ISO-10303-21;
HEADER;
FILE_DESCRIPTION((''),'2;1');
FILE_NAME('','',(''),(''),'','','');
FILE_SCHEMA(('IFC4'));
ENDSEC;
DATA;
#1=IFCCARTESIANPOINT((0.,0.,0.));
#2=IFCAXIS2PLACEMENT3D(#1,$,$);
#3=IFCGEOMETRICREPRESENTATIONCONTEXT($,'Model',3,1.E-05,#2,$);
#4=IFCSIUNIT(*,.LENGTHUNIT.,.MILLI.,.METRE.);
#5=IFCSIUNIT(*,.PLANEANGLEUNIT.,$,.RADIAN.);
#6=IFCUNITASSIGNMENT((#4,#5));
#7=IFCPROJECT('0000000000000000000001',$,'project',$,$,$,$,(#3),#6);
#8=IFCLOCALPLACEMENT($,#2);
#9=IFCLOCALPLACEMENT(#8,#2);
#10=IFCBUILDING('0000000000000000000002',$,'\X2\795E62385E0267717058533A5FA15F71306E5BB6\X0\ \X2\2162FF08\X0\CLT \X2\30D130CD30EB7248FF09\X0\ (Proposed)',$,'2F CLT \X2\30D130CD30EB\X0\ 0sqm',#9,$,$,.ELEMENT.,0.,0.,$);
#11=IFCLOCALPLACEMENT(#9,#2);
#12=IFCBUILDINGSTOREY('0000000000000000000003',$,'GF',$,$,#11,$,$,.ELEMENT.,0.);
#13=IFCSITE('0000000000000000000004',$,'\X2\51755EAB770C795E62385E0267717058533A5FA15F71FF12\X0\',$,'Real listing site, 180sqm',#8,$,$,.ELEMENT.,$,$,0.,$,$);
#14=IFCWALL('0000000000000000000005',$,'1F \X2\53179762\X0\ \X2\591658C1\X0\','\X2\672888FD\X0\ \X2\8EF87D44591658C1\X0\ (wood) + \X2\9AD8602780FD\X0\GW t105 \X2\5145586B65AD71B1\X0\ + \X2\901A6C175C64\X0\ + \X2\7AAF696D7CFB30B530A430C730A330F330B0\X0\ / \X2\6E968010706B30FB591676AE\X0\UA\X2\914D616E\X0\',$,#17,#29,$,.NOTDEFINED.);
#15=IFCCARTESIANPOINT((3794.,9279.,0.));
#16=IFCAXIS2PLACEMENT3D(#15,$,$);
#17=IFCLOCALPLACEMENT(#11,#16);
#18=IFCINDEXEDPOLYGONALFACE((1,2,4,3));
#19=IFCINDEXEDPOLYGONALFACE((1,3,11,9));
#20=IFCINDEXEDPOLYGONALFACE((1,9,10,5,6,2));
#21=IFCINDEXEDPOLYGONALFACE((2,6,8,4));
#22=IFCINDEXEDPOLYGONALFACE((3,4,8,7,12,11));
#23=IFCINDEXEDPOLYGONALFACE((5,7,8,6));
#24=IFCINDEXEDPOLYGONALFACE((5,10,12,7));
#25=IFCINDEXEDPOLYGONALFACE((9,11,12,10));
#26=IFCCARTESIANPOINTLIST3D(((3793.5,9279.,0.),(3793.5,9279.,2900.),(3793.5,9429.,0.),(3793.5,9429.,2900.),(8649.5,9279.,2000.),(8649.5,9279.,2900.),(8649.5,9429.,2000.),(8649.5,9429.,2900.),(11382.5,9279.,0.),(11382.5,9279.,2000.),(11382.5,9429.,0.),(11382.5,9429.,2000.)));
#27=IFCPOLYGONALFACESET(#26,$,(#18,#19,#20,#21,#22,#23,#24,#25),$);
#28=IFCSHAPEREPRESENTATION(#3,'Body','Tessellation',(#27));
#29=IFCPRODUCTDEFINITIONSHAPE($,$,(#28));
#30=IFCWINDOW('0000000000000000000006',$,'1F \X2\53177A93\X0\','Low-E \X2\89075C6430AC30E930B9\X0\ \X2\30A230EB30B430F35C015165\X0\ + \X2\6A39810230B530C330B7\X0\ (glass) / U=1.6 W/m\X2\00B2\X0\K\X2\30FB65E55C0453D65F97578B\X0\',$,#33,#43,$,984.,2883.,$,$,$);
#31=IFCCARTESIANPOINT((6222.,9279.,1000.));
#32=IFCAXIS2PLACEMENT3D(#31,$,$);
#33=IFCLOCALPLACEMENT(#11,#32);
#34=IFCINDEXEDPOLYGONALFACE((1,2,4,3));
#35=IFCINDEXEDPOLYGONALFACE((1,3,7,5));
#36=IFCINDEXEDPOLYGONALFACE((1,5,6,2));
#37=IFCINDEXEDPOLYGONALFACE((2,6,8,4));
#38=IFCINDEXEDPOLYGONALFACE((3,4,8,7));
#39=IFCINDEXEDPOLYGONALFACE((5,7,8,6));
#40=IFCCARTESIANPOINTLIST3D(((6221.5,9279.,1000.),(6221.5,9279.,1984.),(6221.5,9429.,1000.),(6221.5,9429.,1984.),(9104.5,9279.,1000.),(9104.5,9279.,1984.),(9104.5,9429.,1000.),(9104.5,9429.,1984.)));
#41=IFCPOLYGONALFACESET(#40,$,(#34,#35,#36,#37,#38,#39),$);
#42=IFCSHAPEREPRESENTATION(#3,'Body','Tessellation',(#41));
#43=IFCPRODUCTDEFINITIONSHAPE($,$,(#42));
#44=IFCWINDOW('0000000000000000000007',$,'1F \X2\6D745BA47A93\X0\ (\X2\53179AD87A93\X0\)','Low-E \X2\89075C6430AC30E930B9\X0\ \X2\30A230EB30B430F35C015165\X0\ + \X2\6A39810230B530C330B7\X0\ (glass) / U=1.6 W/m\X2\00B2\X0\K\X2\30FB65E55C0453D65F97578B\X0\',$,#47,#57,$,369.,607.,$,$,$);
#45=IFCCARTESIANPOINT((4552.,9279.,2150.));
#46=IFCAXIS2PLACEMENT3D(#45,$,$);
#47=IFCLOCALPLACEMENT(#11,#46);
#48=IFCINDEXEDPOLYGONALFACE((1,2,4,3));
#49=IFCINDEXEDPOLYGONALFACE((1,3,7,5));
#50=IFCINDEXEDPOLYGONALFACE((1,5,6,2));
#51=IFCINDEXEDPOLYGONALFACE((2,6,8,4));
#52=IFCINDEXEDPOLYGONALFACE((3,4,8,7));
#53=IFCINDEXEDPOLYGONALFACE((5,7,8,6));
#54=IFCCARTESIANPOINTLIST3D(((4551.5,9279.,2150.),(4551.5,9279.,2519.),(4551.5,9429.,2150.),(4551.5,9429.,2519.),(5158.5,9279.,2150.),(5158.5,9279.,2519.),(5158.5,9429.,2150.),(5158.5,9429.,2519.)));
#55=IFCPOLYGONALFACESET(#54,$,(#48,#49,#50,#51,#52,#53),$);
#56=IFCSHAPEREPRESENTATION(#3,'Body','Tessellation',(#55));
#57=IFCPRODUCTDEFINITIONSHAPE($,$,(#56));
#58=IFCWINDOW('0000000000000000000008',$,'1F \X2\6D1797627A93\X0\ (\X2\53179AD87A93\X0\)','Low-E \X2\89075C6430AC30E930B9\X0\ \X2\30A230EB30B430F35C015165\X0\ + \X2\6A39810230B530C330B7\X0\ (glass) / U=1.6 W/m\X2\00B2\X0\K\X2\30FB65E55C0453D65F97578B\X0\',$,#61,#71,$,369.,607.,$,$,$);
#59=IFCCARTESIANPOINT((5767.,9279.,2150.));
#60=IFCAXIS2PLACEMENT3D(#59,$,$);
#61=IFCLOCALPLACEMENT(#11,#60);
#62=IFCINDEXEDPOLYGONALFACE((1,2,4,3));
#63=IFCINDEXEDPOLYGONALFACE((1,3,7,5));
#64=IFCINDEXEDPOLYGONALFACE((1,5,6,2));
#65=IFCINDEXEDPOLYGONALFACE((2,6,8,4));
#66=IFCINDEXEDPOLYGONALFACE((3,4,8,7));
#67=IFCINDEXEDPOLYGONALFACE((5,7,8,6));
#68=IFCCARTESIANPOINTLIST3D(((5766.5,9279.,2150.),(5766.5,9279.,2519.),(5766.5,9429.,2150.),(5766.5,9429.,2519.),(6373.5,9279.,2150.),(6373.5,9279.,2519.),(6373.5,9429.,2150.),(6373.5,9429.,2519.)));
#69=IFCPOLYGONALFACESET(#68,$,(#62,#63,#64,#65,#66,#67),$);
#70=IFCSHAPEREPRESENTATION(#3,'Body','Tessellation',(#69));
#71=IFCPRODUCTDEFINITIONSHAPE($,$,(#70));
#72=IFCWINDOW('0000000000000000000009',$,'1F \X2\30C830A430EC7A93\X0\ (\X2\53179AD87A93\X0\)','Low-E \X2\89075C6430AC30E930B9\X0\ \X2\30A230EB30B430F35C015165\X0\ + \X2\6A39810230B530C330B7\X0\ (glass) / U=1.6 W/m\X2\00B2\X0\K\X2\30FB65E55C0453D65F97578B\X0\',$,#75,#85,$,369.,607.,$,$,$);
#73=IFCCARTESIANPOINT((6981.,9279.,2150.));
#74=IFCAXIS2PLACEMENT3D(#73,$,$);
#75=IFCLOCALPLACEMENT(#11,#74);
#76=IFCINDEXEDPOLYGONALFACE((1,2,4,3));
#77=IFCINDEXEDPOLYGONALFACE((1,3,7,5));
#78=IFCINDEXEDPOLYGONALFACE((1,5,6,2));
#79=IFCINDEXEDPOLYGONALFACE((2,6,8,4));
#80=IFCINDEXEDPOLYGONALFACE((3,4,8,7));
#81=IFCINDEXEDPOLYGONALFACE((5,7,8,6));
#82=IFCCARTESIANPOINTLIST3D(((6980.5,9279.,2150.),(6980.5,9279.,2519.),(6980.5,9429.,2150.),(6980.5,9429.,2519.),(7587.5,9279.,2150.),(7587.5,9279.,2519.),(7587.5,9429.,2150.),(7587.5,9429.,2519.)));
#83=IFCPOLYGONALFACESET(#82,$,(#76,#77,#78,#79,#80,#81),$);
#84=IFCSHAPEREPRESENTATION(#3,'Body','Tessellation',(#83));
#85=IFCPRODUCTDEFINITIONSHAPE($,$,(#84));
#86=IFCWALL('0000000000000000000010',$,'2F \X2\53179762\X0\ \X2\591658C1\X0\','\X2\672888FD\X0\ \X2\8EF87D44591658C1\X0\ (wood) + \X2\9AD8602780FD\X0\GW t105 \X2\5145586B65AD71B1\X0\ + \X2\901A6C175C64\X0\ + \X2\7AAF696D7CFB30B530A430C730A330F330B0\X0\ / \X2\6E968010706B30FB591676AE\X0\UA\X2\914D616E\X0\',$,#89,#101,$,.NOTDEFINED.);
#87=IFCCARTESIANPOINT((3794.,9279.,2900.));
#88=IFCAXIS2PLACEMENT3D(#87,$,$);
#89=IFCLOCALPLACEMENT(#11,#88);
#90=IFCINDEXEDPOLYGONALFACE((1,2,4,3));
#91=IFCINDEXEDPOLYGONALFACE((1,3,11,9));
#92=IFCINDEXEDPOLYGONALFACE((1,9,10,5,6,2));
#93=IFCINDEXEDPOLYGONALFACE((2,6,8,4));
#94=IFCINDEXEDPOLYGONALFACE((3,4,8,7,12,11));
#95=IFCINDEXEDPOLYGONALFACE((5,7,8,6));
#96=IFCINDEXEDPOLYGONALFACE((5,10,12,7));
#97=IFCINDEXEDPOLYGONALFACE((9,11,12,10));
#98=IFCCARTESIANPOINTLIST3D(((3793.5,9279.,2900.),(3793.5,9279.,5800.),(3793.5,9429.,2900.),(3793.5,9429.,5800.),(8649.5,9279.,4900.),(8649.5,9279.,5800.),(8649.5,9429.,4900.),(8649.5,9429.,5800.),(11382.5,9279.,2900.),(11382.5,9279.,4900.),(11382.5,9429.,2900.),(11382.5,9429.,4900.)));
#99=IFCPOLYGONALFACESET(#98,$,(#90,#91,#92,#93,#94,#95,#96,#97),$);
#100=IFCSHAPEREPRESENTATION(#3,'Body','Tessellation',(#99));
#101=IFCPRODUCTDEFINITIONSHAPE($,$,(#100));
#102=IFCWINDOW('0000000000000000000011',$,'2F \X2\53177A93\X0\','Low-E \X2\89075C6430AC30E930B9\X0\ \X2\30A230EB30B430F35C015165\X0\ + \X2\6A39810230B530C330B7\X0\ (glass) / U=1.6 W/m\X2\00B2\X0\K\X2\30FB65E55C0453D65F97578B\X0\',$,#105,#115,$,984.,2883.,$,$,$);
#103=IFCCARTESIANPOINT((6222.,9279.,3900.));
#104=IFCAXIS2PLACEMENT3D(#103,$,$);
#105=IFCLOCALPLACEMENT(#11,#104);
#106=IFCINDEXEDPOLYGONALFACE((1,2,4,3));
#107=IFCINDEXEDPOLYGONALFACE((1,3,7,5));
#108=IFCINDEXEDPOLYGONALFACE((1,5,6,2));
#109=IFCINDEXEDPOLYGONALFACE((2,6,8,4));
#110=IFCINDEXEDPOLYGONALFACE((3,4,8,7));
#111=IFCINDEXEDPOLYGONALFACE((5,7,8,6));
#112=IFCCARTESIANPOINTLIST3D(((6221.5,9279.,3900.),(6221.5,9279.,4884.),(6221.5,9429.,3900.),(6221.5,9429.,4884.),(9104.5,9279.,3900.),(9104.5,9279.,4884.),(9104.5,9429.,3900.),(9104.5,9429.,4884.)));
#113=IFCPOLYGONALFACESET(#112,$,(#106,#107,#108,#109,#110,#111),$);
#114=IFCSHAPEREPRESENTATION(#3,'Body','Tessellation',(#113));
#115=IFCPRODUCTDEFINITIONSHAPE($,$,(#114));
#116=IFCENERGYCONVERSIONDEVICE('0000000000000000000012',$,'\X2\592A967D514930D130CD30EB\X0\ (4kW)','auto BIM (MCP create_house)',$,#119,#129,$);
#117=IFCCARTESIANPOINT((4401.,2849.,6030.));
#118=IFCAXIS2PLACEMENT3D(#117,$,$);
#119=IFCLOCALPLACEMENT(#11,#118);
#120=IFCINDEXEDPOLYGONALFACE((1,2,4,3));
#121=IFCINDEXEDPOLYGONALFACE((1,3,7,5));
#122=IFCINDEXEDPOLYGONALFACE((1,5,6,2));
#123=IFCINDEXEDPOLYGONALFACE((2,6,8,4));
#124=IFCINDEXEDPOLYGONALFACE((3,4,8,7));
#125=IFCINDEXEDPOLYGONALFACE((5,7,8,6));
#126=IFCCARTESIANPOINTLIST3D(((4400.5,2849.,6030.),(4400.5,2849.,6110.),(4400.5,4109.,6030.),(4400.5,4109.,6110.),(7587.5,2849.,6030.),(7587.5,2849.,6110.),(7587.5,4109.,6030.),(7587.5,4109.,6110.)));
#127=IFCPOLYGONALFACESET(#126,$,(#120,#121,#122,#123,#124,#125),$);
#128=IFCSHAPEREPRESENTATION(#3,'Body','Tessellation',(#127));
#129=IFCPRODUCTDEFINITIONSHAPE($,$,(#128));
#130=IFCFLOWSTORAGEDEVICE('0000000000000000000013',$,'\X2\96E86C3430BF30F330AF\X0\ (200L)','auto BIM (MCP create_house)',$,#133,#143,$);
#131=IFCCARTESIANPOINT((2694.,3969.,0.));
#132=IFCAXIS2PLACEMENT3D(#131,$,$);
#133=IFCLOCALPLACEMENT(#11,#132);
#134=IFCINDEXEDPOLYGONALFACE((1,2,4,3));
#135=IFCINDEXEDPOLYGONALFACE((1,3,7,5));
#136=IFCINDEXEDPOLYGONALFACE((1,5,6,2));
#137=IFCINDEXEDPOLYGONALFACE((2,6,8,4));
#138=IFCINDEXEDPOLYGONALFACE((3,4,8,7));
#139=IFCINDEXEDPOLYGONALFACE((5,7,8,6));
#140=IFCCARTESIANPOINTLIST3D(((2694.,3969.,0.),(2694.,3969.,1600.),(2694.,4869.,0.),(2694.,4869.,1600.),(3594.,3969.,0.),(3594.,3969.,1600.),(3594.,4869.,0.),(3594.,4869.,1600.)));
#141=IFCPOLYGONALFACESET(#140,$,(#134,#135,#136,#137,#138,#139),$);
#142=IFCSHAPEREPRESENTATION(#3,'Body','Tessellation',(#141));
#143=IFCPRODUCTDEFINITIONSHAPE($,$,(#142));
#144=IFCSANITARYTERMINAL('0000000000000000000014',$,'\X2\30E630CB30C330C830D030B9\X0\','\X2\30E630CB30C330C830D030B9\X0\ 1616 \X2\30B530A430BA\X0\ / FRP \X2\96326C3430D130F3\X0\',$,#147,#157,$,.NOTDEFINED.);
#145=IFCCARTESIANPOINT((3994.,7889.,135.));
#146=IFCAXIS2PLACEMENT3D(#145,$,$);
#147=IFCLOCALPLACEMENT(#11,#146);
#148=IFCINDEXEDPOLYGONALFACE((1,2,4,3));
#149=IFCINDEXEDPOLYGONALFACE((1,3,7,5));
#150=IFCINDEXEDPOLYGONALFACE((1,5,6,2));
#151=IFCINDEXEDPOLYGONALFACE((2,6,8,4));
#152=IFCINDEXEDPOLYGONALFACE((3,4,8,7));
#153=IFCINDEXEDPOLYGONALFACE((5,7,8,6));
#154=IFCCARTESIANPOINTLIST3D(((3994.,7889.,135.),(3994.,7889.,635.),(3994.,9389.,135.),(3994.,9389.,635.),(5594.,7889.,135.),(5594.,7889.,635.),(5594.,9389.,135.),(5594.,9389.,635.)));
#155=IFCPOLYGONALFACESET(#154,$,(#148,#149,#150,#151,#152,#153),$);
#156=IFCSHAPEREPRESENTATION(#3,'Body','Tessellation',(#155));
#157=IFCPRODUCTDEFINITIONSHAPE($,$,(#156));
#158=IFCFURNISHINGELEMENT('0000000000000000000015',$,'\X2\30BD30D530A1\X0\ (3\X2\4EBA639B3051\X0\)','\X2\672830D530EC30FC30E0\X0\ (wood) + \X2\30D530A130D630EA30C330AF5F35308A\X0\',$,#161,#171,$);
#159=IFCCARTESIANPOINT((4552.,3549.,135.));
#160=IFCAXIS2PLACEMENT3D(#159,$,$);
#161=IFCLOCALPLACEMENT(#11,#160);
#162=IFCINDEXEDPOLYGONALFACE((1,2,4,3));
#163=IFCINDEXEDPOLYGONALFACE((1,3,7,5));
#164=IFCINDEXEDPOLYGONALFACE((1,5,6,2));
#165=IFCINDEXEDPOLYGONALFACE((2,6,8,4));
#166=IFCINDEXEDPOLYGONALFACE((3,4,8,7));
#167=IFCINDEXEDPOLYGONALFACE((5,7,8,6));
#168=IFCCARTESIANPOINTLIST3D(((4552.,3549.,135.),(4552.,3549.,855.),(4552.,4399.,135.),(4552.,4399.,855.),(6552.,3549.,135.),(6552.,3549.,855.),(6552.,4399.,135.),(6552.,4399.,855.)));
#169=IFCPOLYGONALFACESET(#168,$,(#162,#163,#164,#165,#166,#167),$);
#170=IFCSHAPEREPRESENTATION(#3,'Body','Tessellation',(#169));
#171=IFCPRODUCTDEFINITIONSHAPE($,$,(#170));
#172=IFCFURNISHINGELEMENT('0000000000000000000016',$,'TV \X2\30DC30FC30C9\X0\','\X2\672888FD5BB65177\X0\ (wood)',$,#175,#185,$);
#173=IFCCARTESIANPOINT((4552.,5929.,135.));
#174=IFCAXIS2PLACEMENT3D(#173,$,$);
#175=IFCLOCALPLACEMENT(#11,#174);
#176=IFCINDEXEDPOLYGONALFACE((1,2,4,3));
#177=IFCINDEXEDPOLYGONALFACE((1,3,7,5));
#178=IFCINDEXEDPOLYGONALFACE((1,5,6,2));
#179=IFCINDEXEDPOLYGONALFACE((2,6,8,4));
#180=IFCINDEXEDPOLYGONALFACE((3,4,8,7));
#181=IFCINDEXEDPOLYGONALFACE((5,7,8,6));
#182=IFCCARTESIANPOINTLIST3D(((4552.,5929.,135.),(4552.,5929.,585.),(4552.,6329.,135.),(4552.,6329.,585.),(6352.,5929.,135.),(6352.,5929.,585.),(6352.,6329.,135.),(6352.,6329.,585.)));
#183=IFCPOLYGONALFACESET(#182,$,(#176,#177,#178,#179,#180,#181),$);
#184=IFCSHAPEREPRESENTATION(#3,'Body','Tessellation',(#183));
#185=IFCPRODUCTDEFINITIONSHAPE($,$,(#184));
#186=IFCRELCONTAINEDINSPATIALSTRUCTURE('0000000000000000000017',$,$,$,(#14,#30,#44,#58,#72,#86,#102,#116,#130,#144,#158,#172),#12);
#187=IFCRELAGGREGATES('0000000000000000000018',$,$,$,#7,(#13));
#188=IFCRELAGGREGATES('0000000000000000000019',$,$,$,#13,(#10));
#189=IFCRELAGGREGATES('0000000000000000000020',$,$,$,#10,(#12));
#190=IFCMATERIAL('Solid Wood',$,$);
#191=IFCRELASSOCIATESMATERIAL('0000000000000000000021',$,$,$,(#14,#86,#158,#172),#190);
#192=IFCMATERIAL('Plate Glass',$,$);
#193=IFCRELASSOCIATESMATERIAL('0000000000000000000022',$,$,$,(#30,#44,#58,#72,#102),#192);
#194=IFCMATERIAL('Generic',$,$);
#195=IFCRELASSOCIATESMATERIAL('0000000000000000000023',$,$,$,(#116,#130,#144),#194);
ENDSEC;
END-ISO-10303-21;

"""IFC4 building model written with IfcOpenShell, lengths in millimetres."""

from ifc_helpers import new_model, si_unit, frame, frame_2d, origin, place, context, project, spatial, rectangle, extrude, material, element, fill, save


model = new_model("IFC4")

# Units and contexts
model_context = context("Model", 3, precision=1e-05, world=origin())
ifc_project = project(units=[si_unit("LENGTHUNIT", "METRE", prefix="MILLI"), si_unit("PLANEANGLEUNIT", "RADIAN")], contexts=[model_context])

# Site, building, storey
site_placement = place(None, origin())
site = spatial("IfcSite", under=ifc_project, at=site_placement, Name="兵庫県神戸市東灘区御影２", ObjectType="Real listing site, 180sqm", CompositionType="ELEMENT", RefElevation=0.0)
building_placement = place(site_placement, origin())
building = spatial("IfcBuilding", under=site, at=building_placement, Name="神戸市東灘区御影の家 Ⅲ（CLT パネル版） (Proposed)", ObjectType="2F CLT パネル 0sqm", CompositionType="ELEMENT", ElevationOfRefHeight=0.0, ElevationOfTerrain=0.0)
storey_placement = place(building_placement, origin())
storey = spatial("IfcBuildingStorey", under=building, at=storey_placement, Name="GF", CompositionType="ELEMENT", Elevation=0.0)

# Wall, openings, windows
ifc_material_1 = material(Name="Solid Wood")
wall_1_placement = place(storey_placement, frame((3794.0, 9279.0, 0.0)))
wall_1 = element("IfcWall", 1, at=wall_1_placement, inside=storey, material=ifc_material_1, Name="1F 北面 外壁", Description="木製 軸組外壁 (wood) + 高性能GW t105 充填断熱 + 通気層 + 窯業系サイディング / 準耐火・外皮UA配慮", PredefinedType="NOTDEFINED", context=model_context, shape_type="SweptSolid", body=[
    extrude(rectangle(XDim=7589.0, YDim=150.0, at=frame_2d((3794.0, 75.0))), frame((3794.0, 9279.0, 0.0)), (0.0, 0.0, 1.0), 2900.0),
])
opening_1_placement = place(storey_placement, frame((6222.0, 9279.0, 1000.0)))
opening_1 = element("IfcOpeningElement", 2, at=opening_1_placement, cuts=wall_1, PredefinedType="NOTDEFINED", context=model_context, shape_type="SweptSolid", body=[
    extrude(rectangle(XDim=2883.0, YDim=150.0, at=frame_2d((1441.0, 75.0))), frame((6222.0, 9279.0, 1000.0)), (0.0, 0.0, 1.0), 984.0),
])
opening_2_placement = place(storey_placement, frame((4552.0, 9279.0, 2150.0)))
opening_2 = element("IfcOpeningElement", 3, at=opening_2_placement, cuts=wall_1, PredefinedType="NOTDEFINED", context=model_context, shape_type="SweptSolid", body=[
    extrude(rectangle(XDim=607.0, YDim=150.0, at=frame_2d((303.0, 75.0))), frame((4552.0, 9279.0, 2150.0)), (0.0, 0.0, 1.0), 369.0),
])
opening_3_placement = place(storey_placement, frame((5767.0, 9279.0, 2150.0)))
opening_3 = element("IfcOpeningElement", 4, at=opening_3_placement, cuts=wall_1, PredefinedType="NOTDEFINED", context=model_context, shape_type="SweptSolid", body=[
    extrude(rectangle(XDim=607.0, YDim=150.0, at=frame_2d((303.0, 75.0))), frame((5767.0, 9279.0, 2150.0)), (0.0, 0.0, 1.0), 369.0),
])
opening_4_placement = place(storey_placement, frame((6981.0, 9279.0, 2150.0)))
opening_4 = element("IfcOpeningElement", 5, at=opening_4_placement, cuts=wall_1, PredefinedType="NOTDEFINED", context=model_context, shape_type="SweptSolid", body=[
    extrude(rectangle(XDim=607.0, YDim=150.0, at=frame_2d((303.0, 75.0))), frame((6981.0, 9279.0, 2150.0)), (0.0, 0.0, 1.0), 369.0),
])
ifc_material_2 = material(Name="Plate Glass")
window_1_placement = place(storey_placement, frame((6222.0, 9279.0, 1000.0)))
window_1 = element("IfcWindow", 6, at=window_1_placement, inside=storey, material=ifc_material_2, Name="1F 北窓", Description="Low-E 複層ガラス アルゴン封入 + 樹脂サッシ (glass) / U=1.6 W/m²K・日射取得型", OverallHeight=984.0, OverallWidth=2883.0, context=model_context, shape_type="SweptSolid", body=[
    extrude(rectangle(XDim=2883.0, YDim=150.0, at=frame_2d((1441.0, 75.0))), frame((6222.0, 9279.0, 1000.0)), (0.0, 0.0, 1.0), 984.0),
])
fill(opening_1, window_1)
window_2_placement = place(storey_placement, frame((4552.0, 9279.0, 2150.0)))
window_2 = element("IfcWindow", 7, at=window_2_placement, inside=storey, material=ifc_material_2, Name="1F 浴室窓 (北高窓)", Description="Low-E 複層ガラス アルゴン封入 + 樹脂サッシ (glass) / U=1.6 W/m²K・日射取得型", OverallHeight=369.0, OverallWidth=607.0, context=model_context, shape_type="SweptSolid", body=[
    extrude(rectangle(XDim=607.0, YDim=150.0, at=frame_2d((303.0, 75.0))), frame((4552.0, 9279.0, 2150.0)), (0.0, 0.0, 1.0), 369.0),
])
fill(opening_2, window_2)
window_3_placement = place(storey_placement, frame((5767.0, 9279.0, 2150.0)))
window_3 = element("IfcWindow", 8, at=window_3_placement, inside=storey, material=ifc_material_2, Name="1F 洗面窓 (北高窓)", Description="Low-E 複層ガラス アルゴン封入 + 樹脂サッシ (glass) / U=1.6 W/m²K・日射取得型", OverallHeight=369.0, OverallWidth=607.0, context=model_context, shape_type="SweptSolid", body=[
    extrude(rectangle(XDim=607.0, YDim=150.0, at=frame_2d((303.0, 75.0))), frame((5767.0, 9279.0, 2150.0)), (0.0, 0.0, 1.0), 369.0),
])
fill(opening_3, window_3)
window_4_placement = place(storey_placement, frame((6981.0, 9279.0, 2150.0)))
window_4 = element("IfcWindow", 9, at=window_4_placement, inside=storey, material=ifc_material_2, Name="1F トイレ窓 (北高窓)", Description="Low-E 複層ガラス アルゴン封入 + 樹脂サッシ (glass) / U=1.6 W/m²K・日射取得型", OverallHeight=369.0, OverallWidth=607.0, context=model_context, shape_type="SweptSolid", body=[
    extrude(rectangle(XDim=607.0, YDim=150.0, at=frame_2d((303.0, 75.0))), frame((6981.0, 9279.0, 2150.0)), (0.0, 0.0, 1.0), 369.0),
])
fill(opening_4, window_4)

# Wall, opening, window
wall_2_placement = place(storey_placement, frame((3794.0, 9279.0, 2900.0)))
wall_2 = element("IfcWall", 10, at=wall_2_placement, inside=storey, material=ifc_material_1, Name="2F 北面 外壁", Description="木製 軸組外壁 (wood) + 高性能GW t105 充填断熱 + 通気層 + 窯業系サイディング / 準耐火・外皮UA配慮", PredefinedType="NOTDEFINED", context=model_context, shape_type="SweptSolid", body=[
    extrude(rectangle(XDim=7589.0, YDim=150.0, at=frame_2d((3794.0, 75.0))), frame((3794.0, 9279.0, 2900.0)), (0.0, 0.0, 1.0), 2900.0),
])
opening_5_placement = place(storey_placement, frame((6222.0, 9279.0, 3900.0)))
opening_5 = element("IfcOpeningElement", 11, at=opening_5_placement, cuts=wall_2, PredefinedType="NOTDEFINED", context=model_context, shape_type="SweptSolid", body=[
    extrude(rectangle(XDim=2883.0, YDim=150.0, at=frame_2d((1441.0, 75.0))), frame((6222.0, 9279.0, 3900.0)), (0.0, 0.0, 1.0), 984.0),
])
window_5_placement = place(storey_placement, frame((6222.0, 9279.0, 3900.0)))
window_5 = element("IfcWindow", 12, at=window_5_placement, inside=storey, material=ifc_material_2, Name="2F 北窓", Description="Low-E 複層ガラス アルゴン封入 + 樹脂サッシ (glass) / U=1.6 W/m²K・日射取得型", OverallHeight=984.0, OverallWidth=2883.0, context=model_context, shape_type="SweptSolid", body=[
    extrude(rectangle(XDim=2883.0, YDim=150.0, at=frame_2d((1441.0, 75.0))), frame((6222.0, 9279.0, 3900.0)), (0.0, 0.0, 1.0), 984.0),
])
fill(opening_5, window_5)

# Energy conversion device
ifc_material_3 = material(Name="Generic")
energy_conversion_device_placement = place(storey_placement, frame((4401.0, 2849.0, 6030.0)))
element("IfcEnergyConversionDevice", 13, at=energy_conversion_device_placement, inside=storey, material=ifc_material_3, Name="太陽光パネル (4kW)", Description="auto BIM (MCP create_house)", context=model_context, shape_type="SweptSolid", body=[
    extrude(rectangle(XDim=3187.0, YDim=1260.0, at=frame_2d((1593.0, 630.0))), frame((4401.0, 2849.0, 6030.0)), (0.0, 0.0, 1.0), 80.0),
])

# Flow storage device
flow_storage_device_placement = place(storey_placement, frame((2694.0, 3969.0, 0.0)))
element("IfcFlowStorageDevice", 14, at=flow_storage_device_placement, inside=storey, material=ifc_material_3, Name="雨水タンク (200L)", Description="auto BIM (MCP create_house)", context=model_context, shape_type="SweptSolid", body=[
    extrude(rectangle(XDim=900.0, YDim=900.0, at=frame_2d((450.0, 450.0))), frame((2694.0, 3969.0, 0.0)), (0.0, 0.0, 1.0), 1600.0),
])

# Sanitary terminal
sanitary_terminal_placement = place(storey_placement, frame((3994.0, 7889.0, 135.0)))
element("IfcSanitaryTerminal", 15, at=sanitary_terminal_placement, inside=storey, material=ifc_material_3, Name="ユニットバス", Description="ユニットバス 1616 サイズ / FRP 防水パン", PredefinedType="NOTDEFINED", context=model_context, shape_type="SweptSolid", body=[
    extrude(rectangle(XDim=1600.0, YDim=1500.0, at=frame_2d((800.0, 750.0))), frame((3994.0, 7889.0, 135.0)), (0.0, 0.0, 1.0), 500.0),
])

# Furnishing elements
furnishing_1_placement = place(storey_placement, frame((4552.0, 3549.0, 135.0)))
element("IfcFurnishingElement", 16, at=furnishing_1_placement, inside=storey, material=ifc_material_1, Name="ソファ (3人掛け)", Description="木フレーム (wood) + ファブリック張り", context=model_context, shape_type="SweptSolid", body=[
    extrude(rectangle(XDim=2000.0, YDim=850.0, at=frame_2d((1000.0, 425.0))), frame((4552.0, 3549.0, 135.0)), (0.0, 0.0, 1.0), 720.0),
])
furnishing_2_placement = place(storey_placement, frame((4552.0, 5929.0, 135.0)))
element("IfcFurnishingElement", 17, at=furnishing_2_placement, inside=storey, material=ifc_material_1, Name="TV ボード", Description="木製家具 (wood)", context=model_context, shape_type="SweptSolid", body=[
    extrude(rectangle(XDim=1800.0, YDim=400.0, at=frame_2d((900.0, 200.0))), frame((4552.0, 5929.0, 135.0)), (0.0, 0.0, 1.0), 450.0),
])

save(model, "model.ifc")
